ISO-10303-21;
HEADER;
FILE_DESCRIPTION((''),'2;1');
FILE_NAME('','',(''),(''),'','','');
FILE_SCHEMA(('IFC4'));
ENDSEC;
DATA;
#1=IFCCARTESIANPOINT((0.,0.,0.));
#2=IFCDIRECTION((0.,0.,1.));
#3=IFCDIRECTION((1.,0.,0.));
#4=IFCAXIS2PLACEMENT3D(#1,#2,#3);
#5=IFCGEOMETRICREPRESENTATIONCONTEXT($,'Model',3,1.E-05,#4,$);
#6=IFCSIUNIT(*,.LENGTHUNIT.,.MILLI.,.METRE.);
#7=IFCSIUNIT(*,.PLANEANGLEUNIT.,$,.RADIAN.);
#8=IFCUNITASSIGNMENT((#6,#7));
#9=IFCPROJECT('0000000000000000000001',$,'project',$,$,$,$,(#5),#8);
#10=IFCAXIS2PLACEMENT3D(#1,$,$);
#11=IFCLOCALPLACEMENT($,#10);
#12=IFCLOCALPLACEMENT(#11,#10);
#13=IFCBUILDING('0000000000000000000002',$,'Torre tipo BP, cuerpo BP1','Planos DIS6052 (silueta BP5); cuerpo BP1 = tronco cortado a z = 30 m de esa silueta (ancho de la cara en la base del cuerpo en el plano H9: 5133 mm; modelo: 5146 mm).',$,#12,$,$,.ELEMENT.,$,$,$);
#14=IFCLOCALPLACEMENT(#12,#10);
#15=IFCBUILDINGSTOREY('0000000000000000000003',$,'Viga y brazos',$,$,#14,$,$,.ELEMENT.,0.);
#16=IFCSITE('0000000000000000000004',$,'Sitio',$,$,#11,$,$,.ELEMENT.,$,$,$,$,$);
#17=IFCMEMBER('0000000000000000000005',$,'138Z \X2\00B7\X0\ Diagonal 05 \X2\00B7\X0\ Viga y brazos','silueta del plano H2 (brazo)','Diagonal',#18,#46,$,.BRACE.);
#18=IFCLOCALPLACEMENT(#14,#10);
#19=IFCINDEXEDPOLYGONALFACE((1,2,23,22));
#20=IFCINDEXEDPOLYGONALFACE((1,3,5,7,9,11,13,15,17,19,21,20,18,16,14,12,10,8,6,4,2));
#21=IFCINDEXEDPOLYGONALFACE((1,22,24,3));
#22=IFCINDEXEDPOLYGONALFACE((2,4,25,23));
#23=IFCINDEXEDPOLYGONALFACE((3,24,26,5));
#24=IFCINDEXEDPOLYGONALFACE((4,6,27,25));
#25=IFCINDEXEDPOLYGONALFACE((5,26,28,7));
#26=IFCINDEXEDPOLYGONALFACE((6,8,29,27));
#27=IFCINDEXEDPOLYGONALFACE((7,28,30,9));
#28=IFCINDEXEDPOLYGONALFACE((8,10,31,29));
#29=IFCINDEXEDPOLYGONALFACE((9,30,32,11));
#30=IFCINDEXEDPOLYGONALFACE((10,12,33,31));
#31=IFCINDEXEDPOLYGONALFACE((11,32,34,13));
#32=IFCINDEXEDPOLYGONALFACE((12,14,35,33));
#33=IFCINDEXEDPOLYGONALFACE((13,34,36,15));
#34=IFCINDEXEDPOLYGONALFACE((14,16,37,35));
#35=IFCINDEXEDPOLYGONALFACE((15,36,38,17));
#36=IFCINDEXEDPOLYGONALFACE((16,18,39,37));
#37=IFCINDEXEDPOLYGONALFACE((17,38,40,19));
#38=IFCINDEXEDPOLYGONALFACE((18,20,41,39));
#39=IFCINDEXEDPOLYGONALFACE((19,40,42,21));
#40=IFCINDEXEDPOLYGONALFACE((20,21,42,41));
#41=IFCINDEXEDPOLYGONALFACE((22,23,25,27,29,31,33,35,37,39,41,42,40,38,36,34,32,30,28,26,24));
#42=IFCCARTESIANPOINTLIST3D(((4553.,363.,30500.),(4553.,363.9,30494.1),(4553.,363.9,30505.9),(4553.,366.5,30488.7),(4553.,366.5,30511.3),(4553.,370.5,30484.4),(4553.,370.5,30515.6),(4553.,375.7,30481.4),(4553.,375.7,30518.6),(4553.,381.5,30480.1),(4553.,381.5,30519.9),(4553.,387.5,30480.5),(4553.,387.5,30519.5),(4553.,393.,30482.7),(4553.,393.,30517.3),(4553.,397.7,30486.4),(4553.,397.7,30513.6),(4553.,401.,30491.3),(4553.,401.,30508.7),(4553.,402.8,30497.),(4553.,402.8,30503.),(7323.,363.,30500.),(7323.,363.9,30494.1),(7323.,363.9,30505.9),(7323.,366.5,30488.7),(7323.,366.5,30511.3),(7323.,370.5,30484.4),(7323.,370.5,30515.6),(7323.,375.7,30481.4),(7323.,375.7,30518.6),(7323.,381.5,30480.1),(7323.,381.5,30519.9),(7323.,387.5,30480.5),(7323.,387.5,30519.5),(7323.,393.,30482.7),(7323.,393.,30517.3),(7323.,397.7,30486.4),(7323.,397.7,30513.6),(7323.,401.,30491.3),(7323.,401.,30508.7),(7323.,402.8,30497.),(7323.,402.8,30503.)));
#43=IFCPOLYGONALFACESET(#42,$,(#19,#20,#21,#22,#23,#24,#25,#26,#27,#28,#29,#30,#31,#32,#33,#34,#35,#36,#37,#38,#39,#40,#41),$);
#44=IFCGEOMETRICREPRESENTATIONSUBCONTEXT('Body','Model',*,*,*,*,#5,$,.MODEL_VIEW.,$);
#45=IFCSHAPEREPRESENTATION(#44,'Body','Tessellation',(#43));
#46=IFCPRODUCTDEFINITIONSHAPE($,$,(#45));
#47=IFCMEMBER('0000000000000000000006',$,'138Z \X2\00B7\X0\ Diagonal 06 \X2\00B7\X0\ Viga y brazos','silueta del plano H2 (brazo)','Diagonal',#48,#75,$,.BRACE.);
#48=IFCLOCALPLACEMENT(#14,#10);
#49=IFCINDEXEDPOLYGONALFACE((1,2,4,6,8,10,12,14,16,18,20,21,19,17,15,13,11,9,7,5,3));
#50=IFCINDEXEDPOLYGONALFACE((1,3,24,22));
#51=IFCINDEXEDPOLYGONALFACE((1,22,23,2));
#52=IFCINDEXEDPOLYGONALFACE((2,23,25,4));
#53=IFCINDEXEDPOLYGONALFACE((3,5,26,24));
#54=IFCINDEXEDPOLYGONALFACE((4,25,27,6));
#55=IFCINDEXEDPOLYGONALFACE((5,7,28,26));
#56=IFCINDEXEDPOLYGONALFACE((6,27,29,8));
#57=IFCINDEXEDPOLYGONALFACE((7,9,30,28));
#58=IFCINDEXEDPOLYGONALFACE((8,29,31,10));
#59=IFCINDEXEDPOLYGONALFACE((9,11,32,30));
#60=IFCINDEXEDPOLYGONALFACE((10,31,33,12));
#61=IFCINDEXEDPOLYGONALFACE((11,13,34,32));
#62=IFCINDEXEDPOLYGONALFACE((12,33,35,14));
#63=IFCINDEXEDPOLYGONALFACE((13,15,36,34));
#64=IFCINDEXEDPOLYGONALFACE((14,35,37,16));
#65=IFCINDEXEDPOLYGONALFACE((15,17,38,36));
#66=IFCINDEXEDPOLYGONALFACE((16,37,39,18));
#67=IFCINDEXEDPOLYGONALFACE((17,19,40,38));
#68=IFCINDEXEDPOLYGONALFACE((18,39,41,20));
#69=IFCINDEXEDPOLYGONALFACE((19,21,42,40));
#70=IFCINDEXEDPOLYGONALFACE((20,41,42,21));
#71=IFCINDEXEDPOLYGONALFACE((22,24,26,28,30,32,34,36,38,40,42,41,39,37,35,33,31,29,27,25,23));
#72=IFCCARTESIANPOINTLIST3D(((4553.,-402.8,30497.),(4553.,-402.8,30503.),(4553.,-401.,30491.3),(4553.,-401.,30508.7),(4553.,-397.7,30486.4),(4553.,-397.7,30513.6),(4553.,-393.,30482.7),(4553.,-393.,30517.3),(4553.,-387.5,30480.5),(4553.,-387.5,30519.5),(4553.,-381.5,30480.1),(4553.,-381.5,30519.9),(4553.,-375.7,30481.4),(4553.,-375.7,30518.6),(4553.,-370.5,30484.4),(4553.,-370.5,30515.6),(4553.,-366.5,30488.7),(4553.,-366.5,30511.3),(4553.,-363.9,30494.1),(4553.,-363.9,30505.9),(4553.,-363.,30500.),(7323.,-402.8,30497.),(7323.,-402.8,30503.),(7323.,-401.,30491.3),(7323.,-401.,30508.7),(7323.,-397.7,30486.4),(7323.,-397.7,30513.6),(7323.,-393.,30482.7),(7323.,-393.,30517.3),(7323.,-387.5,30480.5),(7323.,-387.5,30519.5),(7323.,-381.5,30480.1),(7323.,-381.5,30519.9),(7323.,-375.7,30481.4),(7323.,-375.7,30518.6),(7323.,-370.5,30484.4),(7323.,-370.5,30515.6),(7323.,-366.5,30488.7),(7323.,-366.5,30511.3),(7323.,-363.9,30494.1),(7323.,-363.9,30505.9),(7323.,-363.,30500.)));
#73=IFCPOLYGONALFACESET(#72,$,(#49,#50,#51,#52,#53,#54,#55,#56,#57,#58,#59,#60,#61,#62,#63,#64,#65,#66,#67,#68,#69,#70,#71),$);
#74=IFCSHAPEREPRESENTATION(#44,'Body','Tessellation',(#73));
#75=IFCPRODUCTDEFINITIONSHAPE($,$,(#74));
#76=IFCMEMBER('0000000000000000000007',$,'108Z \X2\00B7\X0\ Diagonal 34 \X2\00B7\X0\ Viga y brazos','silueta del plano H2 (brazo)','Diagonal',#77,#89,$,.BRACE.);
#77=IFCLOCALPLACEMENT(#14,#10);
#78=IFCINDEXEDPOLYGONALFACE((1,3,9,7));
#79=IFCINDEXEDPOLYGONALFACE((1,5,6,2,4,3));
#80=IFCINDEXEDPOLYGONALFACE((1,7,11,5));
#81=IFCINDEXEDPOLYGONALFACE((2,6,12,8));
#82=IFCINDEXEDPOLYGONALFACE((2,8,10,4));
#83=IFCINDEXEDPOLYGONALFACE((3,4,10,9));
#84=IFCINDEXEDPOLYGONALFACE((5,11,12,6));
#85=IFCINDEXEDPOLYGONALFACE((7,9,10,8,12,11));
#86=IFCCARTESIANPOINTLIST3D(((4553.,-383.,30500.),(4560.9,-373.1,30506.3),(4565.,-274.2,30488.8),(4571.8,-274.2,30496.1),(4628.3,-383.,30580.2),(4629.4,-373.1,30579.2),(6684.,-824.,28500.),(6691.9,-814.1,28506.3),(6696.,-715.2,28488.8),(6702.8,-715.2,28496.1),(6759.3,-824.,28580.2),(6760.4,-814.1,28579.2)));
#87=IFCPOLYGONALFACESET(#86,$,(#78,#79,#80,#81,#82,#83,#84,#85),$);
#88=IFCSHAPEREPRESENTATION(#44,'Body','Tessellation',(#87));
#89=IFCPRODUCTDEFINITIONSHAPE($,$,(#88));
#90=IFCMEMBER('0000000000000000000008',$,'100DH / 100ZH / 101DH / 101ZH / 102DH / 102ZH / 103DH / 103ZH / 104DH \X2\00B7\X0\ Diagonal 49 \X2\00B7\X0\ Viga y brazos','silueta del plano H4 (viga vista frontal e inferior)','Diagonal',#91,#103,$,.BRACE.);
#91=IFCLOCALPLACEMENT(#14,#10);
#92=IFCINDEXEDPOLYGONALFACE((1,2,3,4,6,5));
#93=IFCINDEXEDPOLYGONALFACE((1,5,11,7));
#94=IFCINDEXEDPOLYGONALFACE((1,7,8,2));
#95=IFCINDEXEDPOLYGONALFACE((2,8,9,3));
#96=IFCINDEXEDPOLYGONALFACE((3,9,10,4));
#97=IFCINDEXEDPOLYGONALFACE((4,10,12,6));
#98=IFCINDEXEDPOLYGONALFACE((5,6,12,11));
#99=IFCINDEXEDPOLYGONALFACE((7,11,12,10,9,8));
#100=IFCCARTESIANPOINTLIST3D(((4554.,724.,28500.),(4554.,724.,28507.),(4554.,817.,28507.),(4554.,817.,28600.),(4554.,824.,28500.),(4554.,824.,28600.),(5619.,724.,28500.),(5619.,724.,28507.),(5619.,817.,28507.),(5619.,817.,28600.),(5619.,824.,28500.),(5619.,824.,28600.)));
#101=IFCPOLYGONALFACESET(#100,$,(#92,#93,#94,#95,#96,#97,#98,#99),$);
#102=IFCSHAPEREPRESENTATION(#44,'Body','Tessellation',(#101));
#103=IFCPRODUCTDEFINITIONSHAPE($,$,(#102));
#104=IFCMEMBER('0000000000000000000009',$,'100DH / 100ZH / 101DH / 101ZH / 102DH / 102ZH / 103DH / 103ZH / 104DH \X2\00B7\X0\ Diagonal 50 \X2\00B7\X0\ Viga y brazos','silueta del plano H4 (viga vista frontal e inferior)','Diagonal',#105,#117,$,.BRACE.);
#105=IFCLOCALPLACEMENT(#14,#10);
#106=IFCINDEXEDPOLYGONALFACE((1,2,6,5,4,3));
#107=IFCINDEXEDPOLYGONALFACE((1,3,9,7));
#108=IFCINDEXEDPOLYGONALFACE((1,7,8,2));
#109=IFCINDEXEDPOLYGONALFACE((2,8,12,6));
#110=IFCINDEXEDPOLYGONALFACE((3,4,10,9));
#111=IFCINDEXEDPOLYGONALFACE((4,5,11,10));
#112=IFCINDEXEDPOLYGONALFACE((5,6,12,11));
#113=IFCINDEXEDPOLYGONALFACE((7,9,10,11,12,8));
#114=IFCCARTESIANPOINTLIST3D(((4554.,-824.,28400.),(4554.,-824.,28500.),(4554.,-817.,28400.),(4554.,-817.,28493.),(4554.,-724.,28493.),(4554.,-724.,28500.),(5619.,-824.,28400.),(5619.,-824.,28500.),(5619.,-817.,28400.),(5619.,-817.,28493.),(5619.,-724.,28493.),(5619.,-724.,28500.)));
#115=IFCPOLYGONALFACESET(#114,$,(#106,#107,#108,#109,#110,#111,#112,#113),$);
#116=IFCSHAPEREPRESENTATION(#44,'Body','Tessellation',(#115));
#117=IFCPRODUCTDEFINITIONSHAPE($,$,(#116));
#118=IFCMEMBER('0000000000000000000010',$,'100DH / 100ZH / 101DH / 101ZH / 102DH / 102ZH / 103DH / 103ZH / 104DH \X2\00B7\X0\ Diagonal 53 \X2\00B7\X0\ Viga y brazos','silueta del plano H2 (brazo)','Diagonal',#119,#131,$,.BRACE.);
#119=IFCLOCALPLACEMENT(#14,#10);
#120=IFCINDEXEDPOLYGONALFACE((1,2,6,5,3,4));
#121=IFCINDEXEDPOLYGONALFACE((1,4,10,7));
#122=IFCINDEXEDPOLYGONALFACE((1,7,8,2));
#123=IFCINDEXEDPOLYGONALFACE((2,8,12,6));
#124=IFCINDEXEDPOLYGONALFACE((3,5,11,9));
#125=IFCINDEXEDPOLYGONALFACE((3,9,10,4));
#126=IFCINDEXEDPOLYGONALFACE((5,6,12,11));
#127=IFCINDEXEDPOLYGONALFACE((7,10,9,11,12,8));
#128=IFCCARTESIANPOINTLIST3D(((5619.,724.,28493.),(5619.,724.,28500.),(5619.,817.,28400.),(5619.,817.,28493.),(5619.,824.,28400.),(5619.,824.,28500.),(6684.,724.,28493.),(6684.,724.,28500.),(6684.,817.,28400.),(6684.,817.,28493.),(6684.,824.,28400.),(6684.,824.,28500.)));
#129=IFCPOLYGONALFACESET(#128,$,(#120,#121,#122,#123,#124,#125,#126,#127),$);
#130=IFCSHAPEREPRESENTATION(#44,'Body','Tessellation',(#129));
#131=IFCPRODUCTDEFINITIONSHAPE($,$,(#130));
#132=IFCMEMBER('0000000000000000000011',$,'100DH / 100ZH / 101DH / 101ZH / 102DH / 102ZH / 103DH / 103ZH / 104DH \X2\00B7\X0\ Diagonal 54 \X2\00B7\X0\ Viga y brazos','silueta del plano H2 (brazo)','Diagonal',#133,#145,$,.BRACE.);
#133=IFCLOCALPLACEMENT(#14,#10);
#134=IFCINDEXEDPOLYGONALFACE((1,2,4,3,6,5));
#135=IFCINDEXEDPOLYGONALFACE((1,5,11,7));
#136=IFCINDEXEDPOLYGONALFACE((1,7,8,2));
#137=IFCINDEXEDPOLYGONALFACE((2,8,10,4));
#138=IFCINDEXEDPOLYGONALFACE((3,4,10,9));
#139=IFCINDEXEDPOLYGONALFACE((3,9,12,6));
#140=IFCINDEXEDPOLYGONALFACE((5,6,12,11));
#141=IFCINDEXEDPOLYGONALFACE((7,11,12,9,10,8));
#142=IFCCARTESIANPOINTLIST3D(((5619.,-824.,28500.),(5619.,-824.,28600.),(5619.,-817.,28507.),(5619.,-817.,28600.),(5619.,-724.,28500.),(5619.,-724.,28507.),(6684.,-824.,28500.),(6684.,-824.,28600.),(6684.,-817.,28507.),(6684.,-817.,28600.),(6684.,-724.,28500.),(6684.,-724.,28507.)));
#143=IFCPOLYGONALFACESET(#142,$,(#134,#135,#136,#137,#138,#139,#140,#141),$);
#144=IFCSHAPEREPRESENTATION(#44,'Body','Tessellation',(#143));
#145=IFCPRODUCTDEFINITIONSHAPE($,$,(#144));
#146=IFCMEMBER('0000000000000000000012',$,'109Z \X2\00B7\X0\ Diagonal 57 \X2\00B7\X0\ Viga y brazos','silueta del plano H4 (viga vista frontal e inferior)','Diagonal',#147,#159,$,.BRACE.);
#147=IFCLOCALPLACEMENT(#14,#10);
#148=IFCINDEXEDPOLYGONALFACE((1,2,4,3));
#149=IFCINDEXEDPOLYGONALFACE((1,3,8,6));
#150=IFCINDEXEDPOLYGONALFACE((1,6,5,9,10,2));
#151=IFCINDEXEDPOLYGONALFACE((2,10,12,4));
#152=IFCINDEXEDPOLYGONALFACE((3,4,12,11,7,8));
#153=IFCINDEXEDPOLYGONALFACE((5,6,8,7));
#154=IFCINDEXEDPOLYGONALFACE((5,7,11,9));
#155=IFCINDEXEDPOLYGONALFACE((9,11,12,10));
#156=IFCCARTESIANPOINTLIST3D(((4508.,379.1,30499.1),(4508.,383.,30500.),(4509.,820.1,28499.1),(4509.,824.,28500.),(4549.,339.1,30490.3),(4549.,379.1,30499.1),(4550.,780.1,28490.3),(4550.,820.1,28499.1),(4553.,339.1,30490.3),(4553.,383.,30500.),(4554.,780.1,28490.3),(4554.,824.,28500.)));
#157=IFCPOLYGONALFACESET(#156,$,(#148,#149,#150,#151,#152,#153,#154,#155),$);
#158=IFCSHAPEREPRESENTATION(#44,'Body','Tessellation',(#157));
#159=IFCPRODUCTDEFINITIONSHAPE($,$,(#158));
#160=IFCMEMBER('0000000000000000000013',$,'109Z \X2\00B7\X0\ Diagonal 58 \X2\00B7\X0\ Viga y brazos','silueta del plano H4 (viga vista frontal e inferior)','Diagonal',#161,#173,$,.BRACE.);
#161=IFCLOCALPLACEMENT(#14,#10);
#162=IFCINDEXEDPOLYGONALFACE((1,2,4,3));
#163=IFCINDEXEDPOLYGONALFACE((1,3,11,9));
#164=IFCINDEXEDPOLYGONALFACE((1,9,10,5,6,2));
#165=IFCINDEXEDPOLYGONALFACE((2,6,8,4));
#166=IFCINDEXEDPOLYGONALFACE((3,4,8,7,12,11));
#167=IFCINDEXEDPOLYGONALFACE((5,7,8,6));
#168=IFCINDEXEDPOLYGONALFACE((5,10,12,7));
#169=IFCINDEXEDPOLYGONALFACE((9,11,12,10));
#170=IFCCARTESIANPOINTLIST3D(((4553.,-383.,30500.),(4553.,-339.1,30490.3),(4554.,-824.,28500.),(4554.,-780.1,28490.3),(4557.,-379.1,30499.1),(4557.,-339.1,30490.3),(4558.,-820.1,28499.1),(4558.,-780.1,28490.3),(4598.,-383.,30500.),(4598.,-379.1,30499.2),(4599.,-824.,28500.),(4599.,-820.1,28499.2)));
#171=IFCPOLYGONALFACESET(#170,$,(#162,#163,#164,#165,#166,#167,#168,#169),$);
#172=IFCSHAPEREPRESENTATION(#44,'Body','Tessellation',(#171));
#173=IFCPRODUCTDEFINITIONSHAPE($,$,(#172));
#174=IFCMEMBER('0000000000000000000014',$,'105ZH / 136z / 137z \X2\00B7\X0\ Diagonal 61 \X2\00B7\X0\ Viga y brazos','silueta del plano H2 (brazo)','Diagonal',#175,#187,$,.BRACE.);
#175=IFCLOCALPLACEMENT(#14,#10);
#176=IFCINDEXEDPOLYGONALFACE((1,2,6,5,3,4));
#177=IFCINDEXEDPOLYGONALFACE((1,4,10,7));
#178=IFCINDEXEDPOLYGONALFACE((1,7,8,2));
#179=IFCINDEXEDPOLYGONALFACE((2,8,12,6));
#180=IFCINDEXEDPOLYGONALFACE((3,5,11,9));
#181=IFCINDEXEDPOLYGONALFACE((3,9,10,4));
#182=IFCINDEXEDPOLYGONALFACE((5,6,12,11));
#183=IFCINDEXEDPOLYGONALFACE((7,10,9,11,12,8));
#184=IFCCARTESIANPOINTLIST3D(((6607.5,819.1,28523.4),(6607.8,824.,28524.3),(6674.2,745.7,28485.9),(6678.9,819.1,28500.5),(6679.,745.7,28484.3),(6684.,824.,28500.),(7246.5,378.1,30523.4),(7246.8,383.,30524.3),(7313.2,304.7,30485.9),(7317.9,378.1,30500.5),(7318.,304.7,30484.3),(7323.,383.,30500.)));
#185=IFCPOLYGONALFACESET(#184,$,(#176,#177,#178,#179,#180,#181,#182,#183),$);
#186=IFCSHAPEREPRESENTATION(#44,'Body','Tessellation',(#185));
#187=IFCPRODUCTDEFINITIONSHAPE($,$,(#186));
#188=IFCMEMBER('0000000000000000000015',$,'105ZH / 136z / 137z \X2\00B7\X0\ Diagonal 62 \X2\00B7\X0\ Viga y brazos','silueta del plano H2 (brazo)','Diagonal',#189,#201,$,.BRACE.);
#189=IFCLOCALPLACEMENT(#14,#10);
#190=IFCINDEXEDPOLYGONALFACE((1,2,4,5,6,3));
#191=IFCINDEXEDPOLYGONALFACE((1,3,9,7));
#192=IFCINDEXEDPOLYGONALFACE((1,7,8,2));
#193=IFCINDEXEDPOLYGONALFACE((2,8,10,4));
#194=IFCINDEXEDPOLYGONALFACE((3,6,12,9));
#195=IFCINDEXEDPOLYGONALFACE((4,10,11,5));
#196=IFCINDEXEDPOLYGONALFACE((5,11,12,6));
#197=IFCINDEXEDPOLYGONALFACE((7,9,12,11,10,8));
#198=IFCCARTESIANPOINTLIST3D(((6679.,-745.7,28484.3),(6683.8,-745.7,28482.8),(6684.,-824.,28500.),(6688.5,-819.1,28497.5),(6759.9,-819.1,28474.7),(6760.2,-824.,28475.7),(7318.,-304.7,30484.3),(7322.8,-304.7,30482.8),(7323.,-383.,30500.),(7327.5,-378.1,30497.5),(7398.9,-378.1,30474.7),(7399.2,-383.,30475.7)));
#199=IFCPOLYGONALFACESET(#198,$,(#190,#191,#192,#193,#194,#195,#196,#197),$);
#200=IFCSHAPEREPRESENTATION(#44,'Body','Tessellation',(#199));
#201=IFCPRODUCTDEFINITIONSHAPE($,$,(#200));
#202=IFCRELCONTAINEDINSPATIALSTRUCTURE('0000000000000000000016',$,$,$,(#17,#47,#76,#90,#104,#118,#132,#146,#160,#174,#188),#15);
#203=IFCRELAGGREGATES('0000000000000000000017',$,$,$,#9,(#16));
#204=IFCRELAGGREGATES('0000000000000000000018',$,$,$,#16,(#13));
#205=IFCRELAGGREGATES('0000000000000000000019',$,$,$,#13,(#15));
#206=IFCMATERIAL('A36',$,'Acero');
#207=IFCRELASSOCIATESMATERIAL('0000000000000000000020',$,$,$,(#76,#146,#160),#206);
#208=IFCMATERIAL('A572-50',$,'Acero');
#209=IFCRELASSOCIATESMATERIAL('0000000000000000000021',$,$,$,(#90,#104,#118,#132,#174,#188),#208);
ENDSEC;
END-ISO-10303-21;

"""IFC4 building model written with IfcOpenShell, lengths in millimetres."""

from ifc_helpers import new_model, si_unit, frame, frame_2d, origin, origin_with_axes, place, context, subcontext, project, spatial, circle, l_section, extrude, material, element, save


model = new_model("IFC4")

# Units and contexts
model_context = context("Model", 3, precision=1e-05, world=origin_with_axes())
body_context = subcontext(model_context, "Body", "Model", "MODEL_VIEW")
ifc_project = project(units=[si_unit("LENGTHUNIT", "METRE", prefix="MILLI"), si_unit("PLANEANGLEUNIT", "RADIAN")], contexts=[model_context])

# Site, building, storey
site_placement = place(None, origin())
site = spatial("IfcSite", under=ifc_project, at=site_placement, Name="Sitio", CompositionType="ELEMENT")
building_placement = place(site_placement, origin())
building = spatial("IfcBuilding", under=site, at=building_placement, Name="Torre tipo BP, cuerpo BP1", Description="Planos DIS6052 (silueta BP5); cuerpo BP1 = tronco cortado a z = 30 m de esa silueta (ancho de la cara en la base del cuerpo en el plano H9: 5133 mm; modelo: 5146 mm).", CompositionType="ELEMENT")
storey_placement = place(building_placement, origin())
storey = spatial("IfcBuildingStorey", under=building, at=storey_placement, Name="Viga y brazos", CompositionType="ELEMENT", Elevation=0.0)

# Members
for number, where, z_axis, x_axis, name in (
    (1, (7323.0, 383.0, 30500.0), (-1.0, 0.0, 0.0), (0.0, -1.0, 0.0), "138Z · Diagonal 05 · Viga y brazos"),
    (2, (7323.0, -383.0, 30500.0), (-1.0, 0.0, 0.0), (0.0, 1.0, 0.0), "138Z · Diagonal 06 · Viga y brazos"),
):
    element("IfcMember", number, at=place(storey_placement, frame(where, z_axis=z_axis, x_axis=x_axis)), inside=storey, Name=name, Description="silueta del plano H2 (brazo)", ObjectType="Diagonal", PredefinedType="BRACE", context=body_context, shape_type="SweptSolid", body=[
        extrude(circle(Radius=20.0), None, (0.0, 0.0, 1.0), 2770.0),
    ])
ifc_material_1 = material(Name="A36", Category="Acero")
member_placement = place(storey_placement, frame((4553.0, -383.0, 30500.0), z_axis=(0.721001, -0.149208, -0.676679), x_axis=(0.108797, 0.988806, -0.102109)))
element("IfcMember", 3, at=member_placement, inside=storey, material=ifc_material_1, Name="108Z · Diagonal 34 · Viga y brazos", Description="silueta del plano H2 (brazo)", ObjectType="Diagonal", PredefinedType="BRACE", context=body_context, shape_type="SweptSolid", body=[
    extrude(l_section(Depth=110.0, Width=110.0, Thickness=10.0, at=frame_2d((55.0, 55.0))), None, (0.0, 0.0, 1.0), 2955.6),
])
ifc_material_2 = material(Name="A572-50", Category="Acero")
for number, where, z_axis, x_axis, name, description in (
    (4, (5619.0, 824.0, 28500.0), (-1.0, 0.0, 0.0), (0.0, -1.0, 0.0), "100DH / 100ZH / 101DH / 101ZH / 102DH / 102ZH / 103DH / 103ZH / 104DH · Diagonal 49 · Viga y brazos", "silueta del plano H4 (viga vista frontal e inferior)"),
    (5, (5619.0, -824.0, 28500.0), (-1.0, 0.0, 0.0), (0.0, 1.0, 0.0), "100DH / 100ZH / 101DH / 101ZH / 102DH / 102ZH / 103DH / 103ZH / 104DH · Diagonal 50 · Viga y brazos", "silueta del plano H4 (viga vista frontal e inferior)"),
    (6, (5619.0, 824.0, 28500.0), (1.0, 0.0, 0.0), (0.0, -1.0, 0.0), "100DH / 100ZH / 101DH / 101ZH / 102DH / 102ZH / 103DH / 103ZH / 104DH · Diagonal 53 · Viga y brazos", "silueta del plano H2 (brazo)"),
    (7, (5619.0, -824.0, 28500.0), (1.0, 0.0, 0.0), (0.0, 1.0, 0.0), "100DH / 100ZH / 101DH / 101ZH / 102DH / 102ZH / 103DH / 103ZH / 104DH · Diagonal 54 · Viga y brazos", "silueta del plano H2 (brazo)"),
):
    element("IfcMember", number, at=place(storey_placement, frame(where, z_axis=z_axis, x_axis=x_axis)), inside=storey, material=ifc_material_2, Name=name, Description=description, ObjectType="Diagonal", PredefinedType="BRACE", context=body_context, shape_type="SweptSolid", body=[
        extrude(l_section(Depth=100.0, Width=100.0, Thickness=7.0, at=frame_2d((50.0, 50.0))), None, (0.0, 0.0, 1.0), 1065.0),
    ])
for number, where, z_axis, x_axis, name in (
    (8, (4553.0, 383.0, 30500.0), (0.000488, 0.215327, -0.976542), (0.000108, -0.976542, -0.215327), "109Z · Diagonal 57 · Viga y brazos"),
    (9, (4553.0, -383.0, 30500.0), (0.000488, -0.215327, -0.976542), (0.000108, 0.976542, -0.215327), "109Z · Diagonal 58 · Viga y brazos"),
):
    element("IfcMember", number, at=place(storey_placement, frame(where, z_axis=z_axis, x_axis=x_axis)), inside=storey, material=ifc_material_1, Name=name, Description="silueta del plano H4 (viga vista frontal e inferior)", ObjectType="Diagonal", PredefinedType="BRACE", context=body_context, shape_type="SweptSolid", body=[
        extrude(l_section(Depth=45.0, Width=45.0, Thickness=4.0, at=frame_2d((22.5, 22.5))), None, (0.0, 0.0, 1.0), 2048.0),
    ])
for number, where, z_axis, x_axis, name in (
    (10, (7323.0, 383.0, 30500.0), (-0.297845, 0.205555, -0.932221), (-0.062559, -0.978646, -0.195804), "105ZH / 136z / 137z · Diagonal 61 · Viga y brazos"),
    (11, (7323.0, -383.0, 30500.0), (-0.297845, -0.205555, -0.932221), (-0.062559, 0.978646, -0.195804), "105ZH / 136z / 137z · Diagonal 62 · Viga y brazos"),
):
    element("IfcMember", number, at=place(storey_placement, frame(where, z_axis=z_axis, x_axis=x_axis)), inside=storey, material=ifc_material_2, Name=name, Description="silueta del plano H2 (brazo)", ObjectType="Diagonal", PredefinedType="BRACE", context=body_context, shape_type="SweptSolid", body=[
        extrude(l_section(Depth=80.0, Width=80.0, Thickness=5.0, at=frame_2d((40.0, 40.0))), None, (0.0, 0.0, 1.0), 2145.4),
    ])

save(model, "model.ifc")
